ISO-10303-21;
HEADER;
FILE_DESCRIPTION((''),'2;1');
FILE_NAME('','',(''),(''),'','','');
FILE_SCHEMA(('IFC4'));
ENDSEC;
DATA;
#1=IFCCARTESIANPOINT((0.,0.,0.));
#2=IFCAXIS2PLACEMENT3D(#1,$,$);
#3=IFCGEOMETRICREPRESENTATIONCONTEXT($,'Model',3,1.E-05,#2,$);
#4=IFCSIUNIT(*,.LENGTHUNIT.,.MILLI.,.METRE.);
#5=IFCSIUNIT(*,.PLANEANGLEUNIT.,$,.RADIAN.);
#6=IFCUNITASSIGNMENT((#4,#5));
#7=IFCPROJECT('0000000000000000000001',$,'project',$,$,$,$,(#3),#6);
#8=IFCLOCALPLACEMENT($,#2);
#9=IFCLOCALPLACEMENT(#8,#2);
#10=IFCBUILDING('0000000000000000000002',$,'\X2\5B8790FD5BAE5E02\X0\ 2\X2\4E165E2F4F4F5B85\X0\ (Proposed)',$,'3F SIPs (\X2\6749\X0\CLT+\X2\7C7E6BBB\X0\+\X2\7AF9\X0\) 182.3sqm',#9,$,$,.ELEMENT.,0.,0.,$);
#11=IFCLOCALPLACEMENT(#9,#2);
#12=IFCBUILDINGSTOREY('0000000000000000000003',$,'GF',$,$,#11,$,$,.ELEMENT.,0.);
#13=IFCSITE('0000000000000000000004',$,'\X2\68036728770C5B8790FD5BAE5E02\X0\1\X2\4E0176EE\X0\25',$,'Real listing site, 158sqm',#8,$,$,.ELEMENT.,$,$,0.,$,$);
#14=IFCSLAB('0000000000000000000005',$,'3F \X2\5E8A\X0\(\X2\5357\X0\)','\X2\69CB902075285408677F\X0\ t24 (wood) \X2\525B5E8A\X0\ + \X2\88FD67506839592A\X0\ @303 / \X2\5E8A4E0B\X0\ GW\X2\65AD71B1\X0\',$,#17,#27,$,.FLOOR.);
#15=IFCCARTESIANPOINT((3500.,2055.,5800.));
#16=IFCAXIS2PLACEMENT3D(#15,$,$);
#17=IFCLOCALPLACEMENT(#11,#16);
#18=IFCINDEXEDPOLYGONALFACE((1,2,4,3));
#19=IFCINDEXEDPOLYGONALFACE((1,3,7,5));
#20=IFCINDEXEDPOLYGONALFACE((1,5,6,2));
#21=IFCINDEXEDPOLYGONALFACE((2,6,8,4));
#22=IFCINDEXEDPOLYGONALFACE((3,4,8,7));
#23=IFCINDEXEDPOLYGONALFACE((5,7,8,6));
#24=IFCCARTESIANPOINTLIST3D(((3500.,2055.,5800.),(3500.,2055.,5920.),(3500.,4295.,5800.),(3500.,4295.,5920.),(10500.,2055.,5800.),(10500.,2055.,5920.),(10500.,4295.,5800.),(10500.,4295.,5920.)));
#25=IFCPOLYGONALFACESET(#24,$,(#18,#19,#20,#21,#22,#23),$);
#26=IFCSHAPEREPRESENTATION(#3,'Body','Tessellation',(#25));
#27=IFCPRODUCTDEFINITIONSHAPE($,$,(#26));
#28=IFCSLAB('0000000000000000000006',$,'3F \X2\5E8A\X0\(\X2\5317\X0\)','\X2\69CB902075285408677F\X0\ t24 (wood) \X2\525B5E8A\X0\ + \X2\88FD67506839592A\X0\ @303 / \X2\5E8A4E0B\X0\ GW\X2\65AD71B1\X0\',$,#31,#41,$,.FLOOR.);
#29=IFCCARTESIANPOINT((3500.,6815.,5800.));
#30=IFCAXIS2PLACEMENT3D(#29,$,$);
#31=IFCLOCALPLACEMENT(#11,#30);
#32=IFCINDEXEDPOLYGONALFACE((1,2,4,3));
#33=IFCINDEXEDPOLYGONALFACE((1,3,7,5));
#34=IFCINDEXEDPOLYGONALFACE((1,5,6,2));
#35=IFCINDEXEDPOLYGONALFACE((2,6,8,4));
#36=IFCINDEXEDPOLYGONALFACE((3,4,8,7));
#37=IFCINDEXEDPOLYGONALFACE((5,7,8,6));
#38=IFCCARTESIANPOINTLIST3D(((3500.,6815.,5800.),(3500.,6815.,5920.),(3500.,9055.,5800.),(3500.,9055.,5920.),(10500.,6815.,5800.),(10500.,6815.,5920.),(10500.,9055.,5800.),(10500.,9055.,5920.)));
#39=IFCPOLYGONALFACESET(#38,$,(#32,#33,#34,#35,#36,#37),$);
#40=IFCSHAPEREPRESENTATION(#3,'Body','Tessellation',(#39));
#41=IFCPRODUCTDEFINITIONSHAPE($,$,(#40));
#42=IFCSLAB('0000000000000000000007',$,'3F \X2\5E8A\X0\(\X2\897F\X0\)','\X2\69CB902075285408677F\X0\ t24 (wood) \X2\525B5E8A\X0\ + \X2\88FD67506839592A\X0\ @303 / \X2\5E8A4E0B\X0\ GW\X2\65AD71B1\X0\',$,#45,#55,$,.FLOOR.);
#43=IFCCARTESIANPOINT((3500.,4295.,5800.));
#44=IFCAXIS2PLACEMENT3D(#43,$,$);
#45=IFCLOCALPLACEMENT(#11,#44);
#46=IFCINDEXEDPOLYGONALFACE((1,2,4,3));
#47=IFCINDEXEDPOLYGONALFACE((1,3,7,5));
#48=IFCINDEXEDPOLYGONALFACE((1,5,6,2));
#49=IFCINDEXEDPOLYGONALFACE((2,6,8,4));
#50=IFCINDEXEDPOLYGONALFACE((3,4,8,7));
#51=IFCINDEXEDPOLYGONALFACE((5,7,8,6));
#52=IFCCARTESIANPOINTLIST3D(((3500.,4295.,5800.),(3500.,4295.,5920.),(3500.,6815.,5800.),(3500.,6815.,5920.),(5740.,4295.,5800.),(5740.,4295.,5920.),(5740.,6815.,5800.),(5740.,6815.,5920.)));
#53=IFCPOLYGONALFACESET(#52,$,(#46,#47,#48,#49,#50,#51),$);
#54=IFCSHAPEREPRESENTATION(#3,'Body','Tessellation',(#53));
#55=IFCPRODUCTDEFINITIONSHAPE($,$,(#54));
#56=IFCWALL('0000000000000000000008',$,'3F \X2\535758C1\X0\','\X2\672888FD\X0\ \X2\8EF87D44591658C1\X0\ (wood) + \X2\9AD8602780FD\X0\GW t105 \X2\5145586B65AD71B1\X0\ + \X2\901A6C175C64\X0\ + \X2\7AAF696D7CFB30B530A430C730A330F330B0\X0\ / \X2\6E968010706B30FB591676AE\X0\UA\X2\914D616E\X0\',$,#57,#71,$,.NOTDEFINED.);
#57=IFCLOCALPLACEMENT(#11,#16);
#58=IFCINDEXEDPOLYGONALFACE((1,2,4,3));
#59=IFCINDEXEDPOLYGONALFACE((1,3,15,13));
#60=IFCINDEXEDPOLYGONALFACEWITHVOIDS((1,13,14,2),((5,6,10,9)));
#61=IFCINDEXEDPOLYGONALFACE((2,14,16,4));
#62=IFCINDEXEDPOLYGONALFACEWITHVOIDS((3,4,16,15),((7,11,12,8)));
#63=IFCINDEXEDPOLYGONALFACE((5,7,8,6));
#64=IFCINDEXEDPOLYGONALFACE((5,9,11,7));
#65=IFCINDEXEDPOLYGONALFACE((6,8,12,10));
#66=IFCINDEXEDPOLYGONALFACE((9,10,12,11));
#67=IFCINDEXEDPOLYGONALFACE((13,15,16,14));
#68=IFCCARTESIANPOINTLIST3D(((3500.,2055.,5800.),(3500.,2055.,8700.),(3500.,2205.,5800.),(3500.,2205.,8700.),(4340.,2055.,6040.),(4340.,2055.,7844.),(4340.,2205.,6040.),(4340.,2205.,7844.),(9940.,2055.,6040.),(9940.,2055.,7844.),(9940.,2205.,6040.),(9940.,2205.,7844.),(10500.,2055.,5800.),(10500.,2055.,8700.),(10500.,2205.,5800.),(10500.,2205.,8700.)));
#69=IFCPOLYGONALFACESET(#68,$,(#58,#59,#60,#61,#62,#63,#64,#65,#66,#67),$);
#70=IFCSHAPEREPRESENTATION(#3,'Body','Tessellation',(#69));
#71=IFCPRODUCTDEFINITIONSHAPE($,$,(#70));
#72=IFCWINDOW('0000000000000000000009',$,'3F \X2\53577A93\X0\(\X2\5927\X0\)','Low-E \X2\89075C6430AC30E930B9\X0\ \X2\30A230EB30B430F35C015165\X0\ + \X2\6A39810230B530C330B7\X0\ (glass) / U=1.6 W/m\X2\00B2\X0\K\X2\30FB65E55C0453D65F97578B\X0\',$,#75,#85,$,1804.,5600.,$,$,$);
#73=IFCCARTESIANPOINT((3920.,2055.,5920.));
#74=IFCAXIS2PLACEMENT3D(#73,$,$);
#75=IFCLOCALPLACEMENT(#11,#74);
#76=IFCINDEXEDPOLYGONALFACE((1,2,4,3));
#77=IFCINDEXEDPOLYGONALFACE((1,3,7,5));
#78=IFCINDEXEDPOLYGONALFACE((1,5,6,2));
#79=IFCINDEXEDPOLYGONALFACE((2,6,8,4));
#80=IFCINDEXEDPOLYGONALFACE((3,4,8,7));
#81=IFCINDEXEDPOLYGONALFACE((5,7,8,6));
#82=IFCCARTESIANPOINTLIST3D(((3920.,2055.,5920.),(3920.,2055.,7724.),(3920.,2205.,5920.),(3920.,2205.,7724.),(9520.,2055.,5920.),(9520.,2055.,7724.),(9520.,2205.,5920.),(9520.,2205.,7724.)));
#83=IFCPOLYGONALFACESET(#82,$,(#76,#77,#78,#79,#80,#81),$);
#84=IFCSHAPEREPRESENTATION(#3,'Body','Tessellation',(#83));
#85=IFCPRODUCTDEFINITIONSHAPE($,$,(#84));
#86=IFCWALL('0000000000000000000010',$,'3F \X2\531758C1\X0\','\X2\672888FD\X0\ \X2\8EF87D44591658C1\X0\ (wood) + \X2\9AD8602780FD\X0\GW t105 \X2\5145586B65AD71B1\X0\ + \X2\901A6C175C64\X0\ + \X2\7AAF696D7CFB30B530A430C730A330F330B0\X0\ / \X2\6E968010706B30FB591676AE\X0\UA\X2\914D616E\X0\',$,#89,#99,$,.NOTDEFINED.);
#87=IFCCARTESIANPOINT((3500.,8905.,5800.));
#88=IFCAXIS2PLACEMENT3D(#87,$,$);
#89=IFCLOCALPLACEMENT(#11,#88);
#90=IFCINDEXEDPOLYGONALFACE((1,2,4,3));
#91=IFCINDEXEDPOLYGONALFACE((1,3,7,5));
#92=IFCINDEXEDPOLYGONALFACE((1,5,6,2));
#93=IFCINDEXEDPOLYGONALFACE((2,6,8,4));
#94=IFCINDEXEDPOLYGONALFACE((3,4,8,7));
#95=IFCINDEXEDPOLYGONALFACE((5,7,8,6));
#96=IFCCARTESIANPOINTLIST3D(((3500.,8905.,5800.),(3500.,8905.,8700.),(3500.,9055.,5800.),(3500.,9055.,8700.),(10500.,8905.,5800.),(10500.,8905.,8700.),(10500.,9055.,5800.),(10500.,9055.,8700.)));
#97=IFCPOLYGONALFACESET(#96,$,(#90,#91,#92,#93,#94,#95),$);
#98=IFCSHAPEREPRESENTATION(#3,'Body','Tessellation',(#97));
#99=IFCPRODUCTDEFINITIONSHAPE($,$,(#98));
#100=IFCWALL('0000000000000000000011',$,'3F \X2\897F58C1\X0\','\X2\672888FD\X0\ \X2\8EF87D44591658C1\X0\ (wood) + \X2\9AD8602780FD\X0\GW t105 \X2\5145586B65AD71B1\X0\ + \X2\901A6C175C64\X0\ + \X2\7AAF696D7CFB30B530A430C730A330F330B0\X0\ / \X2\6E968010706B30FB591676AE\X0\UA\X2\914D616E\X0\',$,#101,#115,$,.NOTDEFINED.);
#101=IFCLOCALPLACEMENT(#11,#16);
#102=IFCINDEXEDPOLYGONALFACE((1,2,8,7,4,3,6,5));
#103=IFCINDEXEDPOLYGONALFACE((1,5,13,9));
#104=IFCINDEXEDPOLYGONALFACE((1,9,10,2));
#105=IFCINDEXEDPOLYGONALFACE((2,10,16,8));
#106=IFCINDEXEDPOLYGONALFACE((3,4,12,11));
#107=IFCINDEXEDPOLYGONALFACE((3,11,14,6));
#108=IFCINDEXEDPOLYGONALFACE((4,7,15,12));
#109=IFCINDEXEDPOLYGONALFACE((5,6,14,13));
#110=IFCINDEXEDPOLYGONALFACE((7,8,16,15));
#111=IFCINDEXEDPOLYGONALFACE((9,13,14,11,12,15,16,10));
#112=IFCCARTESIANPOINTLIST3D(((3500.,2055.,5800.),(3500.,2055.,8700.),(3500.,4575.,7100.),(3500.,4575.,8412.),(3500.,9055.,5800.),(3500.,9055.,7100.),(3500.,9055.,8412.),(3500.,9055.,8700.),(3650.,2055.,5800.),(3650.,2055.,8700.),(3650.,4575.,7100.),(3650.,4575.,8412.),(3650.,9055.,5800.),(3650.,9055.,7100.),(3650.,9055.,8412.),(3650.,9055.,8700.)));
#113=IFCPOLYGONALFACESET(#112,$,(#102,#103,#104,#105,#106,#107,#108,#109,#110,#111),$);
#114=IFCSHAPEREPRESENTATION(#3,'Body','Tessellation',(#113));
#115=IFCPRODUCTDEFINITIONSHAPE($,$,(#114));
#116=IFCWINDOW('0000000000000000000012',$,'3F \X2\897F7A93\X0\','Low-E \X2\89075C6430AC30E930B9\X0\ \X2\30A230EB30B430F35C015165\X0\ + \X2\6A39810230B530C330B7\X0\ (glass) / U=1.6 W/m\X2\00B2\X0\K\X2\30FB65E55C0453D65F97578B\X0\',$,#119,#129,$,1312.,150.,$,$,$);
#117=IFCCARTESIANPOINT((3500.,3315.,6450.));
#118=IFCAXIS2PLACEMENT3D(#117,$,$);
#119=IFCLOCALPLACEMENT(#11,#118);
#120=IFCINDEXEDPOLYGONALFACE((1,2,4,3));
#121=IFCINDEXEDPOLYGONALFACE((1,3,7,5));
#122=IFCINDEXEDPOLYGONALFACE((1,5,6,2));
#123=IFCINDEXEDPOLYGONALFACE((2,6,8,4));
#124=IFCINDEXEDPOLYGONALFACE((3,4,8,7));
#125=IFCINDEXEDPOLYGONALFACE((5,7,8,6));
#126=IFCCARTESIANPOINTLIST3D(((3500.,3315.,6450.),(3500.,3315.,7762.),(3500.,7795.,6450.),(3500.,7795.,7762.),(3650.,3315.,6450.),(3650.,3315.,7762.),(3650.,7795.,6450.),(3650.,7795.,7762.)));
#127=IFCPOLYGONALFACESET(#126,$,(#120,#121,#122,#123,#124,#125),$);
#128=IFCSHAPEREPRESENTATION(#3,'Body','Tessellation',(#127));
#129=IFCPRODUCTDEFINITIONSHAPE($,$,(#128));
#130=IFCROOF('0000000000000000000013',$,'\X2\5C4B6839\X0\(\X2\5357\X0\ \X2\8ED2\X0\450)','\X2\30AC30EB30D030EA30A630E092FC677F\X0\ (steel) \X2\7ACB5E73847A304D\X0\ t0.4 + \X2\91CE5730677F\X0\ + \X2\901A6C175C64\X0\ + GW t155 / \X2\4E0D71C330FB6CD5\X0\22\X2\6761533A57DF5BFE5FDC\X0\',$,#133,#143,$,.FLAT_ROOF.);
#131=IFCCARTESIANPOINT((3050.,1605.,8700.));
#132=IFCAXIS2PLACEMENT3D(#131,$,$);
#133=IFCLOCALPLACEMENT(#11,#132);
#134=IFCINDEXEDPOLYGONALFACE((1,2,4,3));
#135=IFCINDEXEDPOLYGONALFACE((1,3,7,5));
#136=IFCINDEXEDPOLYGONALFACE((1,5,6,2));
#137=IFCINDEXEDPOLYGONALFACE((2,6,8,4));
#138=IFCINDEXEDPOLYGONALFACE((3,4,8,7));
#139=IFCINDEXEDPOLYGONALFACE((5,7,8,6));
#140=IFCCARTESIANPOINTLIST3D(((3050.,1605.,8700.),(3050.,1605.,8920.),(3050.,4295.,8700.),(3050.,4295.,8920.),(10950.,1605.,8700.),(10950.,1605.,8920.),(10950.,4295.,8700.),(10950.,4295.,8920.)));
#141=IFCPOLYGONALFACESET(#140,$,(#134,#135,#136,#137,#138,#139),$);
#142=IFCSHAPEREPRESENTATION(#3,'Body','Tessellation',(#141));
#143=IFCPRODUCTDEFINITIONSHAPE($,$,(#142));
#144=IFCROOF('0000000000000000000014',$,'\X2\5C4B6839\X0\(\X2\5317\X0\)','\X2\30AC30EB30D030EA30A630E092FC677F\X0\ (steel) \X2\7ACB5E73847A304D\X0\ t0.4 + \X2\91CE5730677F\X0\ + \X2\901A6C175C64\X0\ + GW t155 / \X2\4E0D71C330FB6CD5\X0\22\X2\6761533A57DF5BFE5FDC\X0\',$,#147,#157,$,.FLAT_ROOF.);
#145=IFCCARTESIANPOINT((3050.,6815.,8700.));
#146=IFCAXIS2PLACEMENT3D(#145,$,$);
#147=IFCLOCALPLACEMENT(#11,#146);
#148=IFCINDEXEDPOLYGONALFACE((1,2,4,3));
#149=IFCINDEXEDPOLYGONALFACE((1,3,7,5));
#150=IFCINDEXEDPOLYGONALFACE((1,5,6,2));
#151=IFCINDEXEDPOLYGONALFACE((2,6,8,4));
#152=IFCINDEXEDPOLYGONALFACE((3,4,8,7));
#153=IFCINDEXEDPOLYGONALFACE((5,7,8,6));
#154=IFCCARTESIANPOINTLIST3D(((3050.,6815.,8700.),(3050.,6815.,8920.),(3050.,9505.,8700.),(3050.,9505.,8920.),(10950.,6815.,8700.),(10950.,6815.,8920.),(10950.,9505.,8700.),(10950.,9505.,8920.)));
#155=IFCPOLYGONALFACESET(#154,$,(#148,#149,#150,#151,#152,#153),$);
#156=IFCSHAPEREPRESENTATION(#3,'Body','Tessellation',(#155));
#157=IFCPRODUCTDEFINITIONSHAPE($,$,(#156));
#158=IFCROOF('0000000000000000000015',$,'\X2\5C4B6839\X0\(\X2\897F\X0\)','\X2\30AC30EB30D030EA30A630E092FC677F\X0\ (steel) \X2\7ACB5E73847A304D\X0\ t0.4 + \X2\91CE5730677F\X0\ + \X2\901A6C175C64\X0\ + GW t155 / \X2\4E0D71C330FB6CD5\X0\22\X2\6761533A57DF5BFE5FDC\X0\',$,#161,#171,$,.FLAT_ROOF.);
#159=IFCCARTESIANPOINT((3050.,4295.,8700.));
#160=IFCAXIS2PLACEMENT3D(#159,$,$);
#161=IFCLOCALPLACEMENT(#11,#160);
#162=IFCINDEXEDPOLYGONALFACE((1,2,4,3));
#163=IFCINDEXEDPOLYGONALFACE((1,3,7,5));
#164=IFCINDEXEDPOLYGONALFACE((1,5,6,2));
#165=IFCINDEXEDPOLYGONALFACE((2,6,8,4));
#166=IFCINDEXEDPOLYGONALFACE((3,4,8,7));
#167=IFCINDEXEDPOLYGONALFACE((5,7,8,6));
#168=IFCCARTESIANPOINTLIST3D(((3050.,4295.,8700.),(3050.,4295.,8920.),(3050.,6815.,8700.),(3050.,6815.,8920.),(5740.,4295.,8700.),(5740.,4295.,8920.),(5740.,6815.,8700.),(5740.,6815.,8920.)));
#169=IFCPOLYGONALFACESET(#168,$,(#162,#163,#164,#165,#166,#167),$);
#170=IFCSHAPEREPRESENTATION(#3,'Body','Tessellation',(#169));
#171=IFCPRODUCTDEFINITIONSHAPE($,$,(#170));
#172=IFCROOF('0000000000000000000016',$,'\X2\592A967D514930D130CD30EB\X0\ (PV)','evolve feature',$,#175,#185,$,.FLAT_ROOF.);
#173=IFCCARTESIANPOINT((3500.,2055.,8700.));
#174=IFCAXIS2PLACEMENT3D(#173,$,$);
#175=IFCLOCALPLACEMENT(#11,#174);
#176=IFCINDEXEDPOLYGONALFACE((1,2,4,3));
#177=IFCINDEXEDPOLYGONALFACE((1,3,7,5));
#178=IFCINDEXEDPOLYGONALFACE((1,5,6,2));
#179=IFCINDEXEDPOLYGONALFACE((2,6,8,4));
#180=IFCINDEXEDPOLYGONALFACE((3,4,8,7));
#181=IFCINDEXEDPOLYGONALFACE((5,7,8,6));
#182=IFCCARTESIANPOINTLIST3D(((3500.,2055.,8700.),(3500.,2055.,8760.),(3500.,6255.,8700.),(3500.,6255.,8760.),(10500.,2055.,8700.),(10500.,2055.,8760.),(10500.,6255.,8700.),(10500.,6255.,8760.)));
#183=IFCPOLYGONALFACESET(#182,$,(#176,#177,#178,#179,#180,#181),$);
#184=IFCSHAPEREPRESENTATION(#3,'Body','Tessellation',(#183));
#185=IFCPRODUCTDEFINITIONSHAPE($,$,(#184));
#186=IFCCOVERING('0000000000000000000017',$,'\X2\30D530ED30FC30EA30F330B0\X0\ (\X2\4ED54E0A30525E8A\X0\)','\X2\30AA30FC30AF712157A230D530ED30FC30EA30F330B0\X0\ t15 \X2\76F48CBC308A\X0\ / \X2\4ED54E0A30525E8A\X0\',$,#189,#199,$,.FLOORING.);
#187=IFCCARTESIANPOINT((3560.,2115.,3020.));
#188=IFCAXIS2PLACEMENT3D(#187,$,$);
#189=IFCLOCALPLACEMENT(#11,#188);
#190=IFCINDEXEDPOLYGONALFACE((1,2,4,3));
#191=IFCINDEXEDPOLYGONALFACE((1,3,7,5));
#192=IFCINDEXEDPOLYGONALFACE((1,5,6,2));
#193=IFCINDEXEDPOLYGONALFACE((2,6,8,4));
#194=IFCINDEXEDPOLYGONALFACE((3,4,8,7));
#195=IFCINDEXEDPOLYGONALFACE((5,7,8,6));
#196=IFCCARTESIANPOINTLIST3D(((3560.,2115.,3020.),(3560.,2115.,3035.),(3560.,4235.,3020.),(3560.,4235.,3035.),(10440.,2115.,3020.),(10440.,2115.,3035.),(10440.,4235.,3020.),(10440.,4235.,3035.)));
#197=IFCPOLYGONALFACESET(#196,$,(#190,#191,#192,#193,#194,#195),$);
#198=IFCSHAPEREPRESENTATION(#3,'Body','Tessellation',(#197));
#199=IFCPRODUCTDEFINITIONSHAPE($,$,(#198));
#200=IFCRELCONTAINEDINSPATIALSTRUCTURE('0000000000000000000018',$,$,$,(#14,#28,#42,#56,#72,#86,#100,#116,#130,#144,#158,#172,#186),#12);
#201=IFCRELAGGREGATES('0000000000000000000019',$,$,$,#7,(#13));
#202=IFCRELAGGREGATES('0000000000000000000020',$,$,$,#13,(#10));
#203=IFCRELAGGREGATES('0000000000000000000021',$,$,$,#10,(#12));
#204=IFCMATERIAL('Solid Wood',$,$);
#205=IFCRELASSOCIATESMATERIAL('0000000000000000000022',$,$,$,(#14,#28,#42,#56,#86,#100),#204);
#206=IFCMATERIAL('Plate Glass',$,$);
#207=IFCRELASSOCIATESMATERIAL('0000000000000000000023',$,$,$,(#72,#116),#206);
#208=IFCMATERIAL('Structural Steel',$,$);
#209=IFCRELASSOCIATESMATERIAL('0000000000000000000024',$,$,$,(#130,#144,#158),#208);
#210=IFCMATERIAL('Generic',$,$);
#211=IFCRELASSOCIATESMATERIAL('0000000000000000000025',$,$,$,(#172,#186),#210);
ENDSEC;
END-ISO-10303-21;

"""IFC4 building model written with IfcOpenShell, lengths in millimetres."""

from ifc_helpers import new_model, si_unit, frame, frame_2d, origin, place, context, project, spatial, rectangle, extrude, material, element, fill, save


model = new_model("IFC4")

# Units and contexts
model_context = context("Model", 3, precision=1e-05, world=origin())
ifc_project = project(units=[si_unit("LENGTHUNIT", "METRE", prefix="MILLI"), si_unit("PLANEANGLEUNIT", "RADIAN")], contexts=[model_context])

# Site, building, storey
site_placement = place(None, origin())
site = spatial("IfcSite", under=ifc_project, at=site_placement, Name="栃木県宇都宮市1丁目25", ObjectType="Real listing site, 158sqm", CompositionType="ELEMENT", RefElevation=0.0)
building_placement = place(site_placement, origin())
building = spatial("IfcBuilding", under=site, at=building_placement, Name="宇都宮市 2世帯住宅 (Proposed)", ObjectType="3F SIPs (杉CLT+籾殻+竹) 182.3sqm", CompositionType="ELEMENT", ElevationOfRefHeight=0.0, ElevationOfTerrain=0.0)
storey_placement = place(building_placement, origin())
storey = spatial("IfcBuildingStorey", under=building, at=storey_placement, Name="GF", CompositionType="ELEMENT", Elevation=0.0)

# Slabs
ifc_material_1 = material(Name="Solid Wood")
slab_1_placement = place(storey_placement, frame((3500.0, 2055.0, 5800.0)))
element("IfcSlab", 1, at=slab_1_placement, inside=storey, material=ifc_material_1, Name="3F 床(南)", Description="構造用合板 t24 (wood) 剛床 + 製材根太 @303 / 床下 GW断熱", PredefinedType="FLOOR", context=model_context, shape_type="SweptSolid", body=[
    extrude(rectangle(XDim=7000.0, YDim=2240.0, at=frame_2d((3500.0, 1120.0))), frame((3500.0, 2055.0, 5800.0)), (0.0, 0.0, 1.0), 120.0),
])
slab_2_placement = place(storey_placement, frame((3500.0, 6815.0, 5800.0)))
element("IfcSlab", 2, at=slab_2_placement, inside=storey, material=ifc_material_1, Name="3F 床(北)", Description="構造用合板 t24 (wood) 剛床 + 製材根太 @303 / 床下 GW断熱", PredefinedType="FLOOR", context=model_context, shape_type="SweptSolid", body=[
    extrude(rectangle(XDim=7000.0, YDim=2240.0, at=frame_2d((3500.0, 1120.0))), frame((3500.0, 6815.0, 5800.0)), (0.0, 0.0, 1.0), 120.0),
])
slab_3_placement = place(storey_placement, frame((3500.0, 4295.0, 5800.0)))
element("IfcSlab", 3, at=slab_3_placement, inside=storey, material=ifc_material_1, Name="3F 床(西)", Description="構造用合板 t24 (wood) 剛床 + 製材根太 @303 / 床下 GW断熱", PredefinedType="FLOOR", context=model_context, shape_type="SweptSolid", body=[
    extrude(rectangle(XDim=2240.0, YDim=2520.0, at=frame_2d((1120.0, 1260.0))), frame((3500.0, 4295.0, 5800.0)), (0.0, 0.0, 1.0), 120.0),
])

# Wall, opening, window
wall_1_placement = place(storey_placement, frame((3500.0, 2055.0, 5800.0)))
wall_1 = element("IfcWall", 4, at=wall_1_placement, inside=storey, material=ifc_material_1, Name="3F 南壁", Description="木製 軸組外壁 (wood) + 高性能GW t105 充填断熱 + 通気層 + 窯業系サイディング / 準耐火・外皮UA配慮", PredefinedType="NOTDEFINED", context=model_context, shape_type="SweptSolid", body=[
    extrude(rectangle(XDim=7000.0, YDim=150.0, at=frame_2d((3500.0, 75.0))), frame((3500.0, 2055.0, 5800.0)), (0.0, 0.0, 1.0), 2900.0),
])
opening_1_placement = place(storey_placement, frame((3920.0, 2055.0, 5920.0)))
opening_1 = element("IfcOpeningElement", 5, at=opening_1_placement, cuts=wall_1, PredefinedType="NOTDEFINED", context=model_context, shape_type="SweptSolid", body=[
    extrude(rectangle(XDim=5600.0, YDim=150.0, at=frame_2d((2800.0, 75.0))), frame((3920.0, 2055.0, 5920.0)), (0.0, 0.0, 1.0), 1804.0),
])
ifc_material_2 = material(Name="Plate Glass")
window_1_placement = place(storey_placement, frame((3920.0, 2055.0, 5920.0)))
window_1 = element("IfcWindow", 6, at=window_1_placement, inside=storey, material=ifc_material_2, Name="3F 南窓(大)", Description="Low-E 複層ガラス アルゴン封入 + 樹脂サッシ (glass) / U=1.6 W/m²K・日射取得型", OverallHeight=1804.0, OverallWidth=5600.0, context=model_context, shape_type="SweptSolid", body=[
    extrude(rectangle(XDim=5600.0, YDim=150.0, at=frame_2d((2800.0, 75.0))), frame((3920.0, 2055.0, 5920.0)), (0.0, 0.0, 1.0), 1804.0),
])
fill(opening_1, window_1)

# Wall
wall_2_placement = place(storey_placement, frame((3500.0, 8905.0, 5800.0)))
element("IfcWall", 7, at=wall_2_placement, inside=storey, material=ifc_material_1, Name="3F 北壁", Description="木製 軸組外壁 (wood) + 高性能GW t105 充填断熱 + 通気層 + 窯業系サイディング / 準耐火・外皮UA配慮", PredefinedType="NOTDEFINED", context=model_context, shape_type="SweptSolid", body=[
    extrude(rectangle(XDim=7000.0, YDim=150.0, at=frame_2d((3500.0, 75.0))), frame((3500.0, 8905.0, 5800.0)), (0.0, 0.0, 1.0), 2900.0),
])

# Wall, opening, window
wall_3_placement = place(storey_placement, frame((3500.0, 2055.0, 5800.0)))
wall_3 = element("IfcWall", 8, at=wall_3_placement, inside=storey, material=ifc_material_1, Name="3F 西壁", Description="木製 軸組外壁 (wood) + 高性能GW t105 充填断熱 + 通気層 + 窯業系サイディング / 準耐火・外皮UA配慮", PredefinedType="NOTDEFINED", context=model_context, shape_type="SweptSolid", body=[
    extrude(rectangle(XDim=150.0, YDim=7000.0, at=frame_2d((75.0, 3500.0))), frame((3500.0, 2055.0, 5800.0)), (0.0, 0.0, 1.0), 2900.0),
])
opening_2_placement = place(storey_placement, frame((3500.0, 3315.0, 6450.0)))
opening_2 = element("IfcOpeningElement", 9, at=opening_2_placement, cuts=wall_3, PredefinedType="NOTDEFINED", context=model_context, shape_type="SweptSolid", body=[
    extrude(rectangle(XDim=150.0, YDim=4480.0, at=frame_2d((75.0, 2240.0))), frame((3500.0, 3315.0, 6450.0)), (0.0, 0.0, 1.0), 1312.0),
])
window_2_placement = place(storey_placement, frame((3500.0, 3315.0, 6450.0)))
window_2 = element("IfcWindow", 10, at=window_2_placement, inside=storey, material=ifc_material_2, Name="3F 西窓", Description="Low-E 複層ガラス アルゴン封入 + 樹脂サッシ (glass) / U=1.6 W/m²K・日射取得型", OverallHeight=1312.0, OverallWidth=150.0, context=model_context, shape_type="SweptSolid", body=[
    extrude(rectangle(XDim=150.0, YDim=4480.0, at=frame_2d((75.0, 2240.0))), frame((3500.0, 3315.0, 6450.0)), (0.0, 0.0, 1.0), 1312.0),
])
fill(opening_2, window_2)

# Roofs
ifc_material_3 = material(Name="Structural Steel")
roof_1_placement = place(storey_placement, frame((3050.0, 1605.0, 8700.0)))
element("IfcRoof", 11, at=roof_1_placement, inside=storey, material=ifc_material_3, Name="屋根(南 軒450)", Description="ガルバリウム鋼板 (steel) 立平葺き t0.4 + 野地板 + 通気層 + GW t155 / 不燃・法22条区域対応", PredefinedType="FLAT_ROOF", context=model_context, shape_type="SweptSolid", body=[
    extrude(rectangle(XDim=7900.0, YDim=2690.0, at=frame_2d((3950.0, 1345.0))), frame((3050.0, 1605.0, 8700.0)), (0.0, 0.0, 1.0), 220.0),
])
roof_2_placement = place(storey_placement, frame((3050.0, 6815.0, 8700.0)))
element("IfcRoof", 12, at=roof_2_placement, inside=storey, material=ifc_material_3, Name="屋根(北)", Description="ガルバリウム鋼板 (steel) 立平葺き t0.4 + 野地板 + 通気層 + GW t155 / 不燃・法22条区域対応", PredefinedType="FLAT_ROOF", context=model_context, shape_type="SweptSolid", body=[
    extrude(rectangle(XDim=7900.0, YDim=2690.0, at=frame_2d((3950.0, 1345.0))), frame((3050.0, 6815.0, 8700.0)), (0.0, 0.0, 1.0), 220.0),
])
roof_3_placement = place(storey_placement, frame((3050.0, 4295.0, 8700.0)))
element("IfcRoof", 13, at=roof_3_placement, inside=storey, material=ifc_material_3, Name="屋根(西)", Description="ガルバリウム鋼板 (steel) 立平葺き t0.4 + 野地板 + 通気層 + GW t155 / 不燃・法22条区域対応", PredefinedType="FLAT_ROOF", context=model_context, shape_type="SweptSolid", body=[
    extrude(rectangle(XDim=2690.0, YDim=2520.0, at=frame_2d((1345.0, 1260.0))), frame((3050.0, 4295.0, 8700.0)), (0.0, 0.0, 1.0), 220.0),
])
ifc_material_4 = material(Name="Generic")
roof_4_placement = place(storey_placement, frame((3500.0, 2055.0, 8700.0)))
element("IfcRoof", 14, at=roof_4_placement, inside=storey, material=ifc_material_4, Name="太陽光パネル (PV)", Description="evolve feature", PredefinedType="FLAT_ROOF", context=model_context, shape_type="SweptSolid", body=[
    extrude(rectangle(XDim=7000.0, YDim=4200.0, at=frame_2d((3500.0, 2100.0))), frame((3500.0, 2055.0, 8700.0)), (0.0, 0.0, 1.0), 60.0),
])

# Covering
covering_1_placement = place(storey_placement, frame((3560.0, 2115.0, 3020.0)))
element("IfcCovering", 15, at=covering_1_placement, inside=storey, material=ifc_material_4, Name="フローリング (仕上げ床)", Description="オーク無垢フローリング t15 直貼り / 仕上げ床", PredefinedType="FLOORING", context=model_context, shape_type="SweptSolid", body=[
    extrude(rectangle(XDim=6880.0, YDim=2120.0, at=frame_2d((3440.0, 1060.0))), frame((3560.0, 2115.0, 3020.0)), (0.0, 0.0, 1.0), 15.0),
])

save(model, "model.ifc")
